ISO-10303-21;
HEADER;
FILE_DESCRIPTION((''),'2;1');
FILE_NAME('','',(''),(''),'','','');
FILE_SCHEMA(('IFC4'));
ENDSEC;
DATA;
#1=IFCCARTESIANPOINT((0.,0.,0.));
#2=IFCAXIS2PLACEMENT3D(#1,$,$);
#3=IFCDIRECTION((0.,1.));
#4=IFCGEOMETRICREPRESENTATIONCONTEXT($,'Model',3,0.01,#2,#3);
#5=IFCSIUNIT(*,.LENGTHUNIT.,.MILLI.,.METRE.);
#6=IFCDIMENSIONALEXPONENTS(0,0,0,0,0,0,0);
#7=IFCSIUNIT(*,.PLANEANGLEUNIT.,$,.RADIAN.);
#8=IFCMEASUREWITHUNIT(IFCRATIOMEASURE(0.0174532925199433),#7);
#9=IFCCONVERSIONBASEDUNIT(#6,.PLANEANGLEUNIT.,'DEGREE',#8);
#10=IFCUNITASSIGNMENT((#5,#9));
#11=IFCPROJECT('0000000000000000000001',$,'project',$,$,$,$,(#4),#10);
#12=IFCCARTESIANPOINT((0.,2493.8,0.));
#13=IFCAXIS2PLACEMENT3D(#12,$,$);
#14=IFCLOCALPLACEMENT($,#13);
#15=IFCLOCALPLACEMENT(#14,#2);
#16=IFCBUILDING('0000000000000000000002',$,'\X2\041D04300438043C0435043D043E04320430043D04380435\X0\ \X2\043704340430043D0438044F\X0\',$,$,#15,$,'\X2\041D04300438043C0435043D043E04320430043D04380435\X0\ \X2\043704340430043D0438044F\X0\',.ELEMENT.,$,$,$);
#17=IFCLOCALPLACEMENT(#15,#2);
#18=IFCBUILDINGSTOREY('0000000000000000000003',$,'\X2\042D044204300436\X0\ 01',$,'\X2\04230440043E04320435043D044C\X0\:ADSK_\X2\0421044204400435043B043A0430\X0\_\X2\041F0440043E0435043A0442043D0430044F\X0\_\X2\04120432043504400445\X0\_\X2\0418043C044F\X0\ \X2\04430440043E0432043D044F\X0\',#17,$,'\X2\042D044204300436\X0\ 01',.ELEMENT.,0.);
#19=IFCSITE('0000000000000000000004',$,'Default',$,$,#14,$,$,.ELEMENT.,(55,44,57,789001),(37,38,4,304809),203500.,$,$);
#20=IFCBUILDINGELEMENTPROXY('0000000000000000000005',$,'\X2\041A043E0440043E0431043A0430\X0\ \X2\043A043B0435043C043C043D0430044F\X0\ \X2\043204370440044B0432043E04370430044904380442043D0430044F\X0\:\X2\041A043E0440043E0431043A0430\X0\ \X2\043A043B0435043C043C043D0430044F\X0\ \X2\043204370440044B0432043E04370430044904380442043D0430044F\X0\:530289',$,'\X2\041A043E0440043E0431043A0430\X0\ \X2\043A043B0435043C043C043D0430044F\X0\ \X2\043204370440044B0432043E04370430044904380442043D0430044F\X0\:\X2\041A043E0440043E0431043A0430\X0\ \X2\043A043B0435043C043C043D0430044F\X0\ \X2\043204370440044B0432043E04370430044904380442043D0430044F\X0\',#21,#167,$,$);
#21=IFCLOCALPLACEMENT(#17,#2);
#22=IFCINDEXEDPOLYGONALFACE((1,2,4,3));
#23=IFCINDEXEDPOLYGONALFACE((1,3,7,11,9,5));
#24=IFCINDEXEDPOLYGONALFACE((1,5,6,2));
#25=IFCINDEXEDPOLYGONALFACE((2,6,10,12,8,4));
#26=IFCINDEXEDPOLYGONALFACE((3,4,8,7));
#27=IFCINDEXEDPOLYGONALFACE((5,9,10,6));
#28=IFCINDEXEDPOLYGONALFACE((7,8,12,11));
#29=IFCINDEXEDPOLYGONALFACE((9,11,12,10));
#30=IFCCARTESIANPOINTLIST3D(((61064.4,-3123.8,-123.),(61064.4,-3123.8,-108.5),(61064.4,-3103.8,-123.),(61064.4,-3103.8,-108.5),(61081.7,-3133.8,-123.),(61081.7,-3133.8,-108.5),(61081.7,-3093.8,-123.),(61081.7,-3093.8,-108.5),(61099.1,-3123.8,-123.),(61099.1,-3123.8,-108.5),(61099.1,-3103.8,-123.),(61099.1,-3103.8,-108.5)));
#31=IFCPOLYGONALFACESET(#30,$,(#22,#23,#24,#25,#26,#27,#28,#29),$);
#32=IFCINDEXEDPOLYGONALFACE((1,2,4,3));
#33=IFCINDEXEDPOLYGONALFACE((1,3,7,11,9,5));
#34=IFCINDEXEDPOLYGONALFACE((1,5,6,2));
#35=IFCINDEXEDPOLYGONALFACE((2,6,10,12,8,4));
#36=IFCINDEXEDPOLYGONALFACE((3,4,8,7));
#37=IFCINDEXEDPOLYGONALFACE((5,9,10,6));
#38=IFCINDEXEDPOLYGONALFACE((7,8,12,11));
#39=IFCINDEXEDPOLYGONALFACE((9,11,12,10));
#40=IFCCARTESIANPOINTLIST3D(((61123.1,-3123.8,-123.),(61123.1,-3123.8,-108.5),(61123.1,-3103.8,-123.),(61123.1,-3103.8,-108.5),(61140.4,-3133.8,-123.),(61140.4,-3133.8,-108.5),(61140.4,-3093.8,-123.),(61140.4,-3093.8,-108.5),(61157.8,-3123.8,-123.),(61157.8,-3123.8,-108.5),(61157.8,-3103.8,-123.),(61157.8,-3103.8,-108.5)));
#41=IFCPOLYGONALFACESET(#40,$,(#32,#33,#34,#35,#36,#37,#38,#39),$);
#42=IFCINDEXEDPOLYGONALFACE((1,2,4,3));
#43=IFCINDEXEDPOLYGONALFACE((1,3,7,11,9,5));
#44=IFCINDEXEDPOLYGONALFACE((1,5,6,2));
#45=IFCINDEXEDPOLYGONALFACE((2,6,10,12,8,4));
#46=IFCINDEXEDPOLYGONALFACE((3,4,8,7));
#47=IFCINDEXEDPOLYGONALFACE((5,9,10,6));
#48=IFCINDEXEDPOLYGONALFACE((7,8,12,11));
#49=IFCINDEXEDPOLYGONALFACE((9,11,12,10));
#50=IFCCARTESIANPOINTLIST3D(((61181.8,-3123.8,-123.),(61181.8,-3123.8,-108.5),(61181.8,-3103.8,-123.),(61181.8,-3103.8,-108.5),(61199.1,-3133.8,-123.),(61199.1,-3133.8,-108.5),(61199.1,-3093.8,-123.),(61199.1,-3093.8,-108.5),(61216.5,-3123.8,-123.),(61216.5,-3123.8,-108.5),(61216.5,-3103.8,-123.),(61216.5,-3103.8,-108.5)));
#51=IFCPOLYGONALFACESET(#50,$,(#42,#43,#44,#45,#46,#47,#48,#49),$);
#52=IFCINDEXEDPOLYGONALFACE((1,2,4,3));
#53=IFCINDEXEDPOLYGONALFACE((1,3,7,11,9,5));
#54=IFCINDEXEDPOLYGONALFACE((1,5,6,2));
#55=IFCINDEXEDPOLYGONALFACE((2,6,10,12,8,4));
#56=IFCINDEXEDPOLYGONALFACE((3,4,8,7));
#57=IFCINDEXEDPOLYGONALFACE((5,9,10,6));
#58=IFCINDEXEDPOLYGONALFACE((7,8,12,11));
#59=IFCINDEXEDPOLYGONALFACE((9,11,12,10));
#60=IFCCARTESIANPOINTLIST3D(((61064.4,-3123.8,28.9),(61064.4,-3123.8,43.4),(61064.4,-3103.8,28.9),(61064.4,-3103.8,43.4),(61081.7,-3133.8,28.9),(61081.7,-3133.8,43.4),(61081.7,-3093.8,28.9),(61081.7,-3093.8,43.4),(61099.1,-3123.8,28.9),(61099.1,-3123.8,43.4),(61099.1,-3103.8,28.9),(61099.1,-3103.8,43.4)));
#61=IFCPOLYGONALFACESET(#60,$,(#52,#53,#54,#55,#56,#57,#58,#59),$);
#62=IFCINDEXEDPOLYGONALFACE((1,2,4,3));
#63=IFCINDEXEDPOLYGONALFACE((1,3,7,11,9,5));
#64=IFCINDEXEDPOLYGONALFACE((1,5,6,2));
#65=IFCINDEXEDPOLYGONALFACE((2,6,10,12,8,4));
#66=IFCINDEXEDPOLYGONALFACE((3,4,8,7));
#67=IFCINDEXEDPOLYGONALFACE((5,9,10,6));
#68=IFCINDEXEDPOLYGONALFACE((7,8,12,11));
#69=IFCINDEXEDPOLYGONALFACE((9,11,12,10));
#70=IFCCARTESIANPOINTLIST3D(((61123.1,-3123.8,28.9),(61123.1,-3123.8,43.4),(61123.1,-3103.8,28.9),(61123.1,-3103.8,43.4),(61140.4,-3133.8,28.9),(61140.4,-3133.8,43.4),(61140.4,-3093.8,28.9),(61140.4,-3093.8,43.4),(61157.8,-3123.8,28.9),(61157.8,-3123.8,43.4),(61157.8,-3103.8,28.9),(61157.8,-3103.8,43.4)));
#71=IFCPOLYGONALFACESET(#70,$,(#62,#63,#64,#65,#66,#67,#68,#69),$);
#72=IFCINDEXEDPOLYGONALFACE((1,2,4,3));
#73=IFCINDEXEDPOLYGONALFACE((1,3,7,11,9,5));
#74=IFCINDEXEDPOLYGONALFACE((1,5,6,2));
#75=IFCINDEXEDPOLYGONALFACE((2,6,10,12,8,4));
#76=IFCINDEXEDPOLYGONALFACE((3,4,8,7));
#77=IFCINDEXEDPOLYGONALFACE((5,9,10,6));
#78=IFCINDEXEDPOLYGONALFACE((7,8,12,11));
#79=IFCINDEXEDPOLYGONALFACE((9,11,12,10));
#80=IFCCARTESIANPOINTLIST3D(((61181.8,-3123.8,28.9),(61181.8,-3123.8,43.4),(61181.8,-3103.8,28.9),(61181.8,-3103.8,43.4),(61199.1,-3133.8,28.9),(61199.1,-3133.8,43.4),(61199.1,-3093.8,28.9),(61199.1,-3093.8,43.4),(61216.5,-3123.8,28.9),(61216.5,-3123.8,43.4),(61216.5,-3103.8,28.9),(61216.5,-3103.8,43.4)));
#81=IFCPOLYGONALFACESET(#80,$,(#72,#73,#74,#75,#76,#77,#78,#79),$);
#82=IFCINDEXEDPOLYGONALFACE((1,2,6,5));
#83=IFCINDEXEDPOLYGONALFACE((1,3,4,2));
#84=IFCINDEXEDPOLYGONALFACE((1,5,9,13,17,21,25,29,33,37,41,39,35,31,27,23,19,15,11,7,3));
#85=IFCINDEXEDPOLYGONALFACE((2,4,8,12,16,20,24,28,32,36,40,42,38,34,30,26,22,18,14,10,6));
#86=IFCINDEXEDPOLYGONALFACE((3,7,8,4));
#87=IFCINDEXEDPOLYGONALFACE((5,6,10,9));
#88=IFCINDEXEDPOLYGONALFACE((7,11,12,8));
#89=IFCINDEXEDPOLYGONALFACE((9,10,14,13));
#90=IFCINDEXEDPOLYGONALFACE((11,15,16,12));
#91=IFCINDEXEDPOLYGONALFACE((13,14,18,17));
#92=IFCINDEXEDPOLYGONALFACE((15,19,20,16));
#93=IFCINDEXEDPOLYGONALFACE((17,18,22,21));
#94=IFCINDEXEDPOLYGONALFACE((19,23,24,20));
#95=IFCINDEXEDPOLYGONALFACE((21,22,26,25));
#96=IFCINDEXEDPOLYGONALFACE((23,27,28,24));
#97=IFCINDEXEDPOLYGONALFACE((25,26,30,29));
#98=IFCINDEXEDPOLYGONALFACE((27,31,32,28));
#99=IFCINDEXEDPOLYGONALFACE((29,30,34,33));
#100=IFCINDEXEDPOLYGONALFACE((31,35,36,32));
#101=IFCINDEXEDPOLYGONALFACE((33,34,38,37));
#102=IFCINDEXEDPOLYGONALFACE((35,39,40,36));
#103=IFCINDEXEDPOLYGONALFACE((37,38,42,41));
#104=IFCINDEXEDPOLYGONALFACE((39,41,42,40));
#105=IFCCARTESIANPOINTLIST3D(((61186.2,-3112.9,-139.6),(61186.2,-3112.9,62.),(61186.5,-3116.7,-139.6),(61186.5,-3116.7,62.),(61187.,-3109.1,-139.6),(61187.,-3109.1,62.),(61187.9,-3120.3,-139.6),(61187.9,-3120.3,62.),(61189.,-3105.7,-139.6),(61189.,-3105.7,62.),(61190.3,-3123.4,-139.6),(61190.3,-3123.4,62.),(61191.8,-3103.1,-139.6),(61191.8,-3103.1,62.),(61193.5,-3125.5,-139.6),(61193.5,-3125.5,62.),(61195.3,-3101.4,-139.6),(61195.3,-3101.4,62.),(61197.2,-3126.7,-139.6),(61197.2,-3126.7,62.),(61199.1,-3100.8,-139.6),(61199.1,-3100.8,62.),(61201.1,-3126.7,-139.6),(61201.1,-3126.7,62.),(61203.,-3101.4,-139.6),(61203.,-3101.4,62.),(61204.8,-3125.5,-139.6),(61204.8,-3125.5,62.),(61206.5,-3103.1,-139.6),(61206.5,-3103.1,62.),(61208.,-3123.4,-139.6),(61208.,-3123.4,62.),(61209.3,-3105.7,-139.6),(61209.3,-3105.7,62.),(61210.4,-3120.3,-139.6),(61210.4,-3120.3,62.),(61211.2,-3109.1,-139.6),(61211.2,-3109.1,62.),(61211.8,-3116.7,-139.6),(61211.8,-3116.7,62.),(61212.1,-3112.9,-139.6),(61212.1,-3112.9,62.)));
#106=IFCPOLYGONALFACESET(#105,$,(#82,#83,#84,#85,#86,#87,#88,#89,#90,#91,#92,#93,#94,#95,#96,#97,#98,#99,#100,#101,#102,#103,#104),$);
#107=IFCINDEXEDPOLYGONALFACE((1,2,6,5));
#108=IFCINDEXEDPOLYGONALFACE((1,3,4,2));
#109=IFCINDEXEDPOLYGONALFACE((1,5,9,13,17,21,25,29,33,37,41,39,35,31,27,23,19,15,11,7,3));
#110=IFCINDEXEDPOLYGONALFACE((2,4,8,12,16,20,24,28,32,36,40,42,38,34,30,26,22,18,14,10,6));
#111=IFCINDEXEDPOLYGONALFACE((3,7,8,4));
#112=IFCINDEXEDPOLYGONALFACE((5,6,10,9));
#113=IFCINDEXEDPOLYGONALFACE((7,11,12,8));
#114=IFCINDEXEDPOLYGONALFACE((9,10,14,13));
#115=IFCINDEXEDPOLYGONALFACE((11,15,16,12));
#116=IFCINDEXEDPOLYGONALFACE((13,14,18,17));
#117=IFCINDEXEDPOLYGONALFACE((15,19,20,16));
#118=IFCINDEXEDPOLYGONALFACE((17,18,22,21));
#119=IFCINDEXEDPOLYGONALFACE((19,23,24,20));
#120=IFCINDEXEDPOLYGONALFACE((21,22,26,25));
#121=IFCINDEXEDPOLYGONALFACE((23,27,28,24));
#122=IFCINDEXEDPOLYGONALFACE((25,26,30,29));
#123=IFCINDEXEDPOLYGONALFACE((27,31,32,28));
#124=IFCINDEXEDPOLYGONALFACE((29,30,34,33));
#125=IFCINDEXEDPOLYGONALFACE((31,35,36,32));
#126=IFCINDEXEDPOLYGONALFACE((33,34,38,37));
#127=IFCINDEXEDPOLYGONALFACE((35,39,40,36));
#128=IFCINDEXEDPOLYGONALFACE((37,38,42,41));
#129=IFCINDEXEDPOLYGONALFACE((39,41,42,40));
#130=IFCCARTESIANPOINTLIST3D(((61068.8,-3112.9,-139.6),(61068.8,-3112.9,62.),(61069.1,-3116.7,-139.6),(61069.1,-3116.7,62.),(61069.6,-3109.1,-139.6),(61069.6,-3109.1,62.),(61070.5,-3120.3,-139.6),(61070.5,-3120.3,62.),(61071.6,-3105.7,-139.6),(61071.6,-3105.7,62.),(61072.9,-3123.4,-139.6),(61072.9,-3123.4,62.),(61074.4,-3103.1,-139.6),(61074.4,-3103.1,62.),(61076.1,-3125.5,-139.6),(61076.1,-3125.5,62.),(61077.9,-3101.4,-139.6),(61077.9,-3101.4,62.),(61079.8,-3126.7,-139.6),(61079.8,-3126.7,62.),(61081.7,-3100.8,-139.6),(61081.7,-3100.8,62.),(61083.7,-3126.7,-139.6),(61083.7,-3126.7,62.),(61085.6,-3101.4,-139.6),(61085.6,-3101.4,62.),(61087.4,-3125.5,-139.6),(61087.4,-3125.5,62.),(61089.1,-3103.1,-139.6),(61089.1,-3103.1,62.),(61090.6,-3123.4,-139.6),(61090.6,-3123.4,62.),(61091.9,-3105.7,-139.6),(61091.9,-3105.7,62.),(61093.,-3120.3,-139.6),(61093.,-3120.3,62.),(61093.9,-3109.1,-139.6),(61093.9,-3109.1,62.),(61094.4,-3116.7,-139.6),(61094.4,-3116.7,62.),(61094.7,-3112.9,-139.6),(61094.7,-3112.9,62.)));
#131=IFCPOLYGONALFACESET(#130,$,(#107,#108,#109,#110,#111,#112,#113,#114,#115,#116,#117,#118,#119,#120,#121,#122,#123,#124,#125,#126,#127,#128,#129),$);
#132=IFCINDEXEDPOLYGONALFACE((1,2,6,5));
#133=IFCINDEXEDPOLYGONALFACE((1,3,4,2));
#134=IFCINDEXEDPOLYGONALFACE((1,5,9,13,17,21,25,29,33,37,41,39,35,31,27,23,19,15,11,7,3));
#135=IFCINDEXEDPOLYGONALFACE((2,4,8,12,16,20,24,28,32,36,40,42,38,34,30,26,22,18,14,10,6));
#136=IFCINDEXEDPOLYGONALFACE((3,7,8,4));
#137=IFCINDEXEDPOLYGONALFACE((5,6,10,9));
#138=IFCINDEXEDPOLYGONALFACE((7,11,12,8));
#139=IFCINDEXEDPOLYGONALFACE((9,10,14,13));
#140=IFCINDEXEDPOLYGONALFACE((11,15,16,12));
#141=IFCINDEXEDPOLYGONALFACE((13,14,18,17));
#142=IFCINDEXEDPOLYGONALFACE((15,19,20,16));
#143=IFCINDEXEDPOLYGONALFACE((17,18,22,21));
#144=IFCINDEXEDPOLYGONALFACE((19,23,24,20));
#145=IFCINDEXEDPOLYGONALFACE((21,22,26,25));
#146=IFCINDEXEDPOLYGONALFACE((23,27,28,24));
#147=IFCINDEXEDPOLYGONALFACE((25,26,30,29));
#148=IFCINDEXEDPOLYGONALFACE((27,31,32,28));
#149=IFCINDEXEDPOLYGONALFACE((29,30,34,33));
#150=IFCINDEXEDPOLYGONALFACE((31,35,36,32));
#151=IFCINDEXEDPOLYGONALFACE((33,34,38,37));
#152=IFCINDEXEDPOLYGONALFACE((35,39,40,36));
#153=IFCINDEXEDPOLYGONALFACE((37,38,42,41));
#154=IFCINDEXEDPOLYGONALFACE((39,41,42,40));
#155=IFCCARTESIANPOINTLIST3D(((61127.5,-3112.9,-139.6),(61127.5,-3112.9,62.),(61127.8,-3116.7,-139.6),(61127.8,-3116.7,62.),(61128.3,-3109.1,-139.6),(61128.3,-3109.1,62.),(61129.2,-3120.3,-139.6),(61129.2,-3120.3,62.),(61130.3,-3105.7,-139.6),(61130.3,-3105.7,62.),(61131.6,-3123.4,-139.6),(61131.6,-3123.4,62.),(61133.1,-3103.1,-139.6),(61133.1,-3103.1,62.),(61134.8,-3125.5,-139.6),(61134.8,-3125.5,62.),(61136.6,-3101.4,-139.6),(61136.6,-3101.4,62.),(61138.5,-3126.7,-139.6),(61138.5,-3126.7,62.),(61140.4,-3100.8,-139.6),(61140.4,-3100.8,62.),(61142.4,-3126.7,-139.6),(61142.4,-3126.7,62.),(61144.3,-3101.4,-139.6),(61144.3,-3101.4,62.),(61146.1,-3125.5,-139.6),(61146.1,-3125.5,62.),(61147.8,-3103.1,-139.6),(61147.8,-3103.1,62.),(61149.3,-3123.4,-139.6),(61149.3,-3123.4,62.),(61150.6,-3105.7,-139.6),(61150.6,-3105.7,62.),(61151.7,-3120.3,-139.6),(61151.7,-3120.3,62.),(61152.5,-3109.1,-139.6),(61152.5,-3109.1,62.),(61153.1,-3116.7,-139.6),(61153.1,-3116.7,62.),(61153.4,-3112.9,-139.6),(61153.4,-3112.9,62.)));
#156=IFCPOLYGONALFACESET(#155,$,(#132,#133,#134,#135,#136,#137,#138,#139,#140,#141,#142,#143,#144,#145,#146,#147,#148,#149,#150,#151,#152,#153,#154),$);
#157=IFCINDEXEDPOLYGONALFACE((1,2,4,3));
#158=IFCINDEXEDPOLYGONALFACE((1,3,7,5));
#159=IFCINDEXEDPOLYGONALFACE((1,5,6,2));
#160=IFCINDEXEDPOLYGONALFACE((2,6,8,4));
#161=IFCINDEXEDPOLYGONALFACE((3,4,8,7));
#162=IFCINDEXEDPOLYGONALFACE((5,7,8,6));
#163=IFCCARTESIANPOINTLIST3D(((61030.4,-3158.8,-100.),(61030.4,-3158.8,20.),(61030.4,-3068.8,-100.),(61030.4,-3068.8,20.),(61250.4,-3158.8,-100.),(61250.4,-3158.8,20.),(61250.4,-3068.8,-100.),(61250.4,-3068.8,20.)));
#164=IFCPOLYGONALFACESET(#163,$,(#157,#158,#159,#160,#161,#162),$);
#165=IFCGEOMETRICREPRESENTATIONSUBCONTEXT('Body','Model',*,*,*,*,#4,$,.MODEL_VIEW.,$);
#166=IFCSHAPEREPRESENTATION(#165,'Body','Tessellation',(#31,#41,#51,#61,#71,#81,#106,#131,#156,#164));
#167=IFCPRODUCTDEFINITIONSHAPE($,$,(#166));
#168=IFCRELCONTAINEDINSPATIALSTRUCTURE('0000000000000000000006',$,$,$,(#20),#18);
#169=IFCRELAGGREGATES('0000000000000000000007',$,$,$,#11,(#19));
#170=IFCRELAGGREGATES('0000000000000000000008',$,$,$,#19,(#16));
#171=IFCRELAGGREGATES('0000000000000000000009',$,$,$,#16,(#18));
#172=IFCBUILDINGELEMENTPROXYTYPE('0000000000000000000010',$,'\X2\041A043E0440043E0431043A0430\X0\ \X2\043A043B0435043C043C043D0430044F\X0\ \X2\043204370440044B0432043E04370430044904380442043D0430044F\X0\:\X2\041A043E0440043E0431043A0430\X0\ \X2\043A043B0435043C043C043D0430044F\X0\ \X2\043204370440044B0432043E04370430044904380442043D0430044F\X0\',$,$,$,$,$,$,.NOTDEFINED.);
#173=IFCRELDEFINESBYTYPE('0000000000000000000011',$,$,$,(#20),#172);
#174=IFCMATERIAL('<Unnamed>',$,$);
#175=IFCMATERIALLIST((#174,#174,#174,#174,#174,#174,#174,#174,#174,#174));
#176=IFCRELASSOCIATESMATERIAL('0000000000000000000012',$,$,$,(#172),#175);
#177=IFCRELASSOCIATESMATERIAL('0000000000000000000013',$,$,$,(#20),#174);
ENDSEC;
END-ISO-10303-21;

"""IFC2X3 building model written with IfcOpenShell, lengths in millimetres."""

from ifc_helpers import new_model, entity, si_unit, converted_unit, direction, frame, frame_2d, origin, place, context, subcontext, project, spatial, polyline, rectangle, circle, outline, extrude, source, transform, mapped, material, material_list, type_object, type_shapes, element, save


model = new_model("IFC2X3")

# Units and contexts
model_context = context("Model", 3, precision=0.01, world=origin(), true_north=direction((0.0, 1.0)))
body_context = subcontext(model_context, "Body", "Model", "MODEL_VIEW")
ifc_project = project(units=[si_unit("LENGTHUNIT", "METRE", prefix="MILLI"), converted_unit("PLANEANGLEUNIT", "DEGREE", entity("IfcRatioMeasure", 0.0174532925199433), si_unit("PLANEANGLEUNIT", "RADIAN"), dimensions=[0, 0, 0, 0, 0, 0, 0])], contexts=[model_context])

# Site, building, storey
site_placement = place(None, frame((0.0, 2493.8, 0.0)))
site = spatial("IfcSite", under=ifc_project, at=site_placement, Name="Default", CompositionType="ELEMENT", RefLatitude=(55, 44, 57, 789001), RefLongitude=(37, 38, 4, 304809), RefElevation=203500.0)
building_placement = place(site_placement, origin())
building = spatial("IfcBuilding", under=site, at=building_placement, Name="Наименование здания", LongName="Наименование здания", CompositionType="ELEMENT")
storey_placement = place(building_placement, origin())
storey = spatial("IfcBuildingStorey", under=building, at=storey_placement, Name="Этаж 01", ObjectType="Уровень:ADSK_Стрелка_Проектная_Вверх_Имя уровня", LongName="Этаж 01", CompositionType="ELEMENT", Elevation=0.0)

# Building element proxy
ifc_material_1 = material(Name="<Unnamed>")
ifc_material_list_1 = material_list([ifc_material_1, ifc_material_1, ifc_material_1, ifc_material_1, ifc_material_1, ifc_material_1, ifc_material_1, ifc_material_1, ifc_material_1, ifc_material_1])
building_element_proxy_type_1 = type_object("IfcBuildingElementProxyType", Name="Коробка клеммная взрывозащитная:Коробка клеммная взрывозащитная", PredefinedType="NOTDEFINED", material=ifc_material_list_1)
shared_shape_1 = source(origin(), body_context, "Body", "SweptSolid", [
    extrude(outline(polyline([(-10.0, -17.3), (10.0, -17.3), (20.0, 0.0), (10.0, 17.3), (-10.0, 17.3), (-20.0, 0.0), (-10.0, -17.3)])), frame((0.0, 58.7, -23.0), z_axis=(0.0, 0.0, 1.0), x_axis=(-1.0, 0.0, 0.0)), (0.0, 0.0, 1.0), 14.4),
    extrude(outline(polyline([(-10.0, -17.3), (10.0, -17.3), (20.0, 0.0), (10.0, 17.3), (-10.0, 17.3), (-20.0, 0.0), (-10.0, -17.3)])), frame((0.0, 0.0, -23.0), z_axis=(0.0, 0.0, 1.0), x_axis=(-1.0, 0.0, 0.0)), (0.0, 0.0, 1.0), 14.4),
    extrude(outline(polyline([(-10.0, -17.3), (10.0, -17.3), (20.0, 0.0), (10.0, 17.3), (-10.0, 17.3), (-20.0, 0.0), (-10.0, -17.3)])), frame((0.0, -58.7, -23.0), z_axis=(0.0, 0.0, 1.0), x_axis=(-1.0, 0.0, 0.0)), (0.0, 0.0, 1.0), 14.4),
    extrude(outline(polyline([(-10.0, -17.3), (10.0, -17.3), (20.0, 0.0), (10.0, 17.3), (-10.0, 17.3), (-20.0, 0.0), (-10.0, -17.3)])), frame((0.0, 58.7, 128.9), z_axis=(0.0, 0.0, 1.0), x_axis=(-1.0, 0.0, 0.0)), (0.0, 0.0, 1.0), 14.4),
    extrude(outline(polyline([(-10.0, -17.3), (10.0, -17.3), (20.0, 0.0), (10.0, 17.3), (-10.0, 17.3), (-20.0, 0.0), (-10.0, -17.3)])), frame((0.0, 0.0, 128.9), z_axis=(0.0, 0.0, 1.0), x_axis=(-1.0, 0.0, 0.0)), (0.0, 0.0, 1.0), 14.4),
    extrude(outline(polyline([(-10.0, -17.3), (10.0, -17.3), (20.0, 0.0), (10.0, 17.3), (-10.0, 17.3), (-20.0, 0.0), (-10.0, -17.3)])), frame((0.0, -58.7, 128.9), z_axis=(0.0, 0.0, 1.0), x_axis=(-1.0, 0.0, 0.0)), (0.0, 0.0, 1.0), 14.4),
    extrude(circle(Radius=13.0, at=frame_2d((0.0, 0.0), x_axis=(1.0, 0.0))), frame((0.0, -58.7, -39.6)), (0.0, 0.0, 1.0), 201.6),
    extrude(circle(Radius=13.0, at=frame_2d((0.0, 0.0), x_axis=(1.0, 0.0))), frame((0.0, 58.7, -39.6)), (0.0, 0.0, 1.0), 201.6),
    extrude(circle(Radius=13.0, at=frame_2d((0.0, 0.0), x_axis=(1.0, 0.0))), frame((0.0, 0.0, -39.6)), (0.0, 0.0, 1.0), 201.6),
    extrude(rectangle(XDim=220.0, YDim=90.0, at=frame_2d((0.0, 0.0), x_axis=(1.0, 0.0))), frame((0.0, 0.0, 0.0), z_axis=(0.0, 0.0, 1.0), x_axis=(0.0, -1.0, 0.0)), (0.0, 0.0, 1.0), 120.0),
])
type_shapes(building_element_proxy_type_1, [shared_shape_1])
for number, where, z_axis, x_axis, name in (
    (1, (61140.4, -3113.8, -100.0), (0.0, 0.0, 1.0), (0.0, 1.0, 0.0), "Коробка клеммная взрывозащитная:Коробка клеммная взрывозащитная:530289"),
):
    element("IfcBuildingElementProxy", number, at=place(storey_placement, frame(where, z_axis=z_axis, x_axis=x_axis)), inside=storey, type_object=building_element_proxy_type_1, material=ifc_material_1, Name=name, ObjectType="Коробка клеммная взрывозащитная:Коробка клеммная взрывозащитная", context=body_context, shape_type="MappedRepresentation", body=[
        mapped(shared_shape_1, transform((0.0, 0.0, 0.0), scale=1.0)),
    ])

save(model, "model.ifc")
